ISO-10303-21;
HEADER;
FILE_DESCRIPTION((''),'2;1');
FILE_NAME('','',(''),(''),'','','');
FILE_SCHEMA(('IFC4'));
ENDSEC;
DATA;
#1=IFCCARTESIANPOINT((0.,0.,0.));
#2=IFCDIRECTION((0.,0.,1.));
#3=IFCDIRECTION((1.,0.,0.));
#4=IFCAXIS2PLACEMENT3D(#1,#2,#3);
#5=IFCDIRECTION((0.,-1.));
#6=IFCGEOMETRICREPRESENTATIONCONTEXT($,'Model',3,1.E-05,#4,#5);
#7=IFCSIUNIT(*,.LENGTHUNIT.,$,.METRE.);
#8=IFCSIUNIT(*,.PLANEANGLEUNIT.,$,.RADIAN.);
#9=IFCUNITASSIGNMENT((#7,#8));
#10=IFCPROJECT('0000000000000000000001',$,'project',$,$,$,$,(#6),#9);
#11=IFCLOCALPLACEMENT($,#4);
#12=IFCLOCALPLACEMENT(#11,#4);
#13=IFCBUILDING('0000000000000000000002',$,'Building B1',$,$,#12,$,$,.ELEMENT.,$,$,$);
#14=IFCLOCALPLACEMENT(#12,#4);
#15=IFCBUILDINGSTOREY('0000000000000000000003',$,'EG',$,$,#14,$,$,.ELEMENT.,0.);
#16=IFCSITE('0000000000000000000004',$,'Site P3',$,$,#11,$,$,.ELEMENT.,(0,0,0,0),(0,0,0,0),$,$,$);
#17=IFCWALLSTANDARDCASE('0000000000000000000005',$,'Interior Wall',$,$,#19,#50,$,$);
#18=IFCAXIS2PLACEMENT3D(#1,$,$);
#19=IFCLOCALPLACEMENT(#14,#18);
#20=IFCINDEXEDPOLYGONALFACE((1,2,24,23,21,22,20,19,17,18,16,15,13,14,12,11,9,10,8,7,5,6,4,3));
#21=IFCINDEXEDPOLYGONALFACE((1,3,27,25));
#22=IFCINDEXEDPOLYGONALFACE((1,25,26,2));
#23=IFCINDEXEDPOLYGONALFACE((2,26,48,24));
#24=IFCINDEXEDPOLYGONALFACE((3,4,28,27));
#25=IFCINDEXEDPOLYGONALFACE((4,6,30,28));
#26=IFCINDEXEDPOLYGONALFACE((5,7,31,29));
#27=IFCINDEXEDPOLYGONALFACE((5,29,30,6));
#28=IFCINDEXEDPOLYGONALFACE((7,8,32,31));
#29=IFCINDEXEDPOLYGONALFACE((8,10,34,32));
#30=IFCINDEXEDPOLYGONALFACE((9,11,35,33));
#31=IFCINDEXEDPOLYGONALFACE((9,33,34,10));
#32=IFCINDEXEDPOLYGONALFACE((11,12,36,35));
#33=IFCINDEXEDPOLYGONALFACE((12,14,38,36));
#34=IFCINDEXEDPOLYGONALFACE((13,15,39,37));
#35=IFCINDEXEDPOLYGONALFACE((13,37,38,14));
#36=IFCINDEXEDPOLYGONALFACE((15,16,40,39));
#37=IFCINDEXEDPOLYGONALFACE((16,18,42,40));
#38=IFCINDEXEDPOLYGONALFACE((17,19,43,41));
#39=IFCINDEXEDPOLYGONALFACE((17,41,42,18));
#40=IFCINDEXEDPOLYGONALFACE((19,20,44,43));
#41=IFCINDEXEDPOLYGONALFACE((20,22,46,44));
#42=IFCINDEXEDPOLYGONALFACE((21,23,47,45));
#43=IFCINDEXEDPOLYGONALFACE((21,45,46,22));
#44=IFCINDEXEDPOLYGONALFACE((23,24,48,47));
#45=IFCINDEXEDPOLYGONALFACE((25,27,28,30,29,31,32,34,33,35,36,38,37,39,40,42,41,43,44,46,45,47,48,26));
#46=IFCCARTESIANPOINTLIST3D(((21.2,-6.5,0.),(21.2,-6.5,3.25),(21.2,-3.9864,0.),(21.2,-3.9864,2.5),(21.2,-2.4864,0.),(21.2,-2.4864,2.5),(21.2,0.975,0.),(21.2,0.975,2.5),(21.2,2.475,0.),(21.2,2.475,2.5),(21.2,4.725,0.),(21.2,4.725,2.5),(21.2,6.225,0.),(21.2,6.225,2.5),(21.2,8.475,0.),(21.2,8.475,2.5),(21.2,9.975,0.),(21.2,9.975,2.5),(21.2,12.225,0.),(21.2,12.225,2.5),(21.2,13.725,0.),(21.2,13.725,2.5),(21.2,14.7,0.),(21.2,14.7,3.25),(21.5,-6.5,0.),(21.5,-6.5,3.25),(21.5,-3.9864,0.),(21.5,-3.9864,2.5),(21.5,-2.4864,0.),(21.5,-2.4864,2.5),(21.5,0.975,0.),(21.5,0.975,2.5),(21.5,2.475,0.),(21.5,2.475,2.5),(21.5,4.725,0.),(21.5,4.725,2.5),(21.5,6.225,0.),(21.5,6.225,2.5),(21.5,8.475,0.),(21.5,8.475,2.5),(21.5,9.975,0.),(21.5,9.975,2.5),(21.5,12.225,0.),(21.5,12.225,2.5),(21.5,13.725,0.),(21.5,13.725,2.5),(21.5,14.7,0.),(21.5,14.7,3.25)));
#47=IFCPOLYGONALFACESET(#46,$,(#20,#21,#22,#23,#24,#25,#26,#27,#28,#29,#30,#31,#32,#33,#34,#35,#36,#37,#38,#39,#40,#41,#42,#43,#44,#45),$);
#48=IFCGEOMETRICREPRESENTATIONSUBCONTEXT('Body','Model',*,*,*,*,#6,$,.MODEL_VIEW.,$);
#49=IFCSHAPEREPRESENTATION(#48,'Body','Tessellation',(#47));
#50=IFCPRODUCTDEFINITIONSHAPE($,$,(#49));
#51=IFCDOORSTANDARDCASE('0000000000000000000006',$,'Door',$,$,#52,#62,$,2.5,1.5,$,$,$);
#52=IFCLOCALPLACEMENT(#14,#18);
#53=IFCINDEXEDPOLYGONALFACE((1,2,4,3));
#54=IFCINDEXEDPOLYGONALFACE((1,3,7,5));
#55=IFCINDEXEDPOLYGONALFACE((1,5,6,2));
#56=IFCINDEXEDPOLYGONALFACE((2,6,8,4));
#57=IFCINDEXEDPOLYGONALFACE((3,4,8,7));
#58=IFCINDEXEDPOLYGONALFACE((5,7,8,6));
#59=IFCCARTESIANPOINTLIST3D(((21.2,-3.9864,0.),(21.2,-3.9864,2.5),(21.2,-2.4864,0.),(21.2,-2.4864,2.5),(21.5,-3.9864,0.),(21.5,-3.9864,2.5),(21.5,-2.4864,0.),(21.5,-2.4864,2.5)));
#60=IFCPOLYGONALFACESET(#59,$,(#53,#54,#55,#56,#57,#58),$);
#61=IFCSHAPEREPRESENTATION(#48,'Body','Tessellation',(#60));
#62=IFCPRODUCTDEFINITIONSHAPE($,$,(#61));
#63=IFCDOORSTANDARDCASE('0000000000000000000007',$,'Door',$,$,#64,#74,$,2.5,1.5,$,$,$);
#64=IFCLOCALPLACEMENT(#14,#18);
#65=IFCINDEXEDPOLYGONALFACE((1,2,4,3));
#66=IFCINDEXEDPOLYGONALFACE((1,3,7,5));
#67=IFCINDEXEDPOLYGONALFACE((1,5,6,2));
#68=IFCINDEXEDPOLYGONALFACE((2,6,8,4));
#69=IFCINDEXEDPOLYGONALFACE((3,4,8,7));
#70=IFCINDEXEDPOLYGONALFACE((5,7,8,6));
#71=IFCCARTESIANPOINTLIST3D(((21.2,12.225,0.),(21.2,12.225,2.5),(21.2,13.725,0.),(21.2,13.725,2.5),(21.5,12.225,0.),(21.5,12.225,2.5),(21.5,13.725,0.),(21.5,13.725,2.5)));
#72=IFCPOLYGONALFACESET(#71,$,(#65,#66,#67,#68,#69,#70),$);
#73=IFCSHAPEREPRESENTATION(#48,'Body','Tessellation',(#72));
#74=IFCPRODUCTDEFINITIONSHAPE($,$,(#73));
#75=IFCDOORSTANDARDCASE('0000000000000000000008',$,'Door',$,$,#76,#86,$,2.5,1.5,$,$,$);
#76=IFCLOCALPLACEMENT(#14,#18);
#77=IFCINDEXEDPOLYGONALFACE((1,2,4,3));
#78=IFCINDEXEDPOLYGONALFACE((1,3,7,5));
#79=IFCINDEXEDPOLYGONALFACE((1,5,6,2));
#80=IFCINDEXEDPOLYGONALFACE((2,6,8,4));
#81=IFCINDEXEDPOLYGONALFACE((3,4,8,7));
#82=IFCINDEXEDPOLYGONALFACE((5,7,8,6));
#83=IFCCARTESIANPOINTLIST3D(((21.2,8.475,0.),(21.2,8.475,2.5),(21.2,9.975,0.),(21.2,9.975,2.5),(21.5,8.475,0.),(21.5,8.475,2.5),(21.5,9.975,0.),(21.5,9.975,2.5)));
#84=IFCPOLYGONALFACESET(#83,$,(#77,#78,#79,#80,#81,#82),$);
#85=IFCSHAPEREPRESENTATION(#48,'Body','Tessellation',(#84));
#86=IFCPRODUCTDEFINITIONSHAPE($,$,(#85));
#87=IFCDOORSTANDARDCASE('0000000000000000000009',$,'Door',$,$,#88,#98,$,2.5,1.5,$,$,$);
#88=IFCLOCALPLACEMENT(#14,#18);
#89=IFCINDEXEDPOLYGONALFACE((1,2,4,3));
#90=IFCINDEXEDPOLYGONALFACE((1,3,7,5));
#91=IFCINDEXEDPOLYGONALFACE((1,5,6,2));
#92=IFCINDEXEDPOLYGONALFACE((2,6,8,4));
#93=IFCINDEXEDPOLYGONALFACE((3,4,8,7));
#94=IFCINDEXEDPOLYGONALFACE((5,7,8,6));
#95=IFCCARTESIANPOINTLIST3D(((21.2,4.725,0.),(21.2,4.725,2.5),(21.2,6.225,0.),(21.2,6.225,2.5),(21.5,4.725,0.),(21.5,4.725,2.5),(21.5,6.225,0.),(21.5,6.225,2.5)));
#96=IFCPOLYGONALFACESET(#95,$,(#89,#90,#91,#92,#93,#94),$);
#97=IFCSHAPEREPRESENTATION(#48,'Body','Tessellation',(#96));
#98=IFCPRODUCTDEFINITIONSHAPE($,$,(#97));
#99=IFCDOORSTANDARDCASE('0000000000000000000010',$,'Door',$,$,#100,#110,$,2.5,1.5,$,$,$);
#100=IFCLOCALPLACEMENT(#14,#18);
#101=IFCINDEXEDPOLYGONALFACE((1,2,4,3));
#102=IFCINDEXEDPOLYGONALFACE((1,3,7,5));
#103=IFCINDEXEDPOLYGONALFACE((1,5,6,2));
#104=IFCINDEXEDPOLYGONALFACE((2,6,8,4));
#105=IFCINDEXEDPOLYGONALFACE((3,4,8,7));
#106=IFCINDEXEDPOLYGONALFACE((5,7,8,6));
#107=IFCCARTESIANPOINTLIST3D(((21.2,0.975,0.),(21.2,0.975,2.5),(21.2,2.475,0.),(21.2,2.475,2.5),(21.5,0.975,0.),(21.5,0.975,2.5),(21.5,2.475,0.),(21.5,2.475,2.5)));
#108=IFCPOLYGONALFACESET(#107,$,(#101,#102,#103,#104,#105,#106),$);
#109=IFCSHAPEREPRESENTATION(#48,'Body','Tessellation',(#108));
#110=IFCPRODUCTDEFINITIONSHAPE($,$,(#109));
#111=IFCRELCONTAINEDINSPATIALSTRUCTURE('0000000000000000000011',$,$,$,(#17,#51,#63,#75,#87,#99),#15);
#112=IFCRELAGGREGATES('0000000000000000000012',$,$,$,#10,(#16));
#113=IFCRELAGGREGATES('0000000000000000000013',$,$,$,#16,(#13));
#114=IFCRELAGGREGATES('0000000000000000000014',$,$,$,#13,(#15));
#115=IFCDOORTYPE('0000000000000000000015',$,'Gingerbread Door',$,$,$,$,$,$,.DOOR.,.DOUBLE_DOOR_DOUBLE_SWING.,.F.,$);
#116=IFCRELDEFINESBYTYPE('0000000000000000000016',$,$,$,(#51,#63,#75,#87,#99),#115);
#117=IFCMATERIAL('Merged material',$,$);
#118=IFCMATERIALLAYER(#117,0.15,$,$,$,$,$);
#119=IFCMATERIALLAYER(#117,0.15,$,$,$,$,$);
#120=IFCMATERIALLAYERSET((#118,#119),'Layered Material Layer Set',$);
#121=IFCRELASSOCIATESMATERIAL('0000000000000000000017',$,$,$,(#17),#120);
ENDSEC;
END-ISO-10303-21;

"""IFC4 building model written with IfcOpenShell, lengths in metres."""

from ifc_helpers import new_model, si_unit, direction, frame, origin_with_axes, place, context, subcontext, project, spatial, polyline, outline, extrude, source, transform, mapped, material, layer, layer_set, layer_usage, type_object, element, fill, save


model = new_model("IFC4")

# Units and contexts
model_context = context("Model", 3, precision=1e-05, world=origin_with_axes(), true_north=direction((0.0, -1.0)))
body_context = subcontext(model_context, "Body", "Model", "MODEL_VIEW")
ifc_project = project(units=[si_unit("LENGTHUNIT", "METRE"), si_unit("PLANEANGLEUNIT", "RADIAN")], contexts=[model_context])

# Site, building, storey
site_placement = place(None, origin_with_axes())
site = spatial("IfcSite", under=ifc_project, at=site_placement, Name="Site P3", CompositionType="ELEMENT", RefLatitude=(0, 0, 0, 0), RefLongitude=(0, 0, 0, 0))
building_placement = place(site_placement, origin_with_axes())
building = spatial("IfcBuilding", under=site, at=building_placement, Name="Building B1", CompositionType="ELEMENT")
storey_placement = place(building_placement, origin_with_axes())
storey = spatial("IfcBuildingStorey", under=building, at=storey_placement, Name="EG", CompositionType="ELEMENT", Elevation=0.0)

# Shared definitions
ifc_material = material(Name="Merged material")

# Wall, openings, doors
ifc_layer_1 = layer(ifc_material, 0.15)
ifc_layer_2 = layer(ifc_material, 0.15)
ifc_layer_set_1 = layer_set([ifc_layer_1, ifc_layer_2], Name="Layered Material Layer Set")
ifc_layer_usage_1 = layer_usage(ifc_layer_set_1, "AXIS2", "POSITIVE", -0.15)
wall_1_placement = place(storey_placement, frame((21.35, 14.7, 0.0), z_axis=(0.0, 0.0, 1.0), x_axis=(0.0, -1.0, 0.0)))
wall_1 = element("IfcWallStandardCase", 1, at=wall_1_placement, inside=storey, material=ifc_layer_usage_1, Name="Interior Wall", context=body_context, shape_type="SweptSolid", body=[
    extrude(outline(polyline([(0.0, 0.15), (21.2, 0.15), (21.2, -0.15), (0.0, -0.15), (0.0, 0.15)])), origin_with_axes(), (0.0, 0.0, 1.0), 3.25),
])
opening_1_placement = place(wall_1_placement, frame((17.1864, 0.0, 0.0), z_axis=(0.0, 0.0, 1.0), x_axis=(1.0, 0.0, 0.0)))
opening_1 = element("IfcOpeningStandardCase", 2, at=opening_1_placement, cuts=wall_1, context=body_context, shape_type="SweptSolid", body=[
    extrude(outline(polyline([(0.0, 0.0), (0.0, 1.5), (2.5, 1.5), (2.5, 0.0), (0.0, 0.0)])), frame((0.0, -0.15, 0.0), z_axis=(0.0, 1.0, 0.0), x_axis=(0.0, 0.0, 1.0)), (0.0, 0.0, 1.0), 0.3),
])
opening_2_placement = place(wall_1_placement, frame((0.975, 0.0, 0.0), z_axis=(0.0, 0.0, 1.0), x_axis=(1.0, 0.0, 0.0)))
opening_2 = element("IfcOpeningStandardCase", 3, at=opening_2_placement, cuts=wall_1, context=body_context, shape_type="SweptSolid", body=[
    extrude(outline(polyline([(0.0, 0.0), (0.0, 1.5), (2.5, 1.5), (2.5, 0.0), (0.0, 0.0)])), frame((0.0, -0.15, 0.0), z_axis=(0.0, 1.0, 0.0), x_axis=(0.0, 0.0, 1.0)), (0.0, 0.0, 1.0), 0.3),
])
opening_3_placement = place(wall_1_placement, frame((4.725, 0.0, 0.0), z_axis=(0.0, 0.0, 1.0), x_axis=(1.0, 0.0, 0.0)))
opening_3 = element("IfcOpeningStandardCase", 4, at=opening_3_placement, cuts=wall_1, context=body_context, shape_type="SweptSolid", body=[
    extrude(outline(polyline([(0.0, 0.0), (0.0, 1.5), (2.5, 1.5), (2.5, 0.0), (0.0, 0.0)])), frame((0.0, -0.15, 0.0), z_axis=(0.0, 1.0, 0.0), x_axis=(0.0, 0.0, 1.0)), (0.0, 0.0, 1.0), 0.3),
])
opening_4_placement = place(wall_1_placement, frame((8.475, 0.0, 0.0), z_axis=(0.0, 0.0, 1.0), x_axis=(1.0, 0.0, 0.0)))
opening_4 = element("IfcOpeningStandardCase", 5, at=opening_4_placement, cuts=wall_1, context=body_context, shape_type="SweptSolid", body=[
    extrude(outline(polyline([(0.0, 0.0), (0.0, 1.5), (2.5, 1.5), (2.5, 0.0), (0.0, 0.0)])), frame((0.0, -0.15, 0.0), z_axis=(0.0, 1.0, 0.0), x_axis=(0.0, 0.0, 1.0)), (0.0, 0.0, 1.0), 0.3),
])
opening_5_placement = place(wall_1_placement, frame((12.225, 0.0, 0.0), z_axis=(0.0, 0.0, 1.0), x_axis=(1.0, 0.0, 0.0)))
opening_5 = element("IfcOpeningStandardCase", 6, at=opening_5_placement, cuts=wall_1, context=body_context, shape_type="SweptSolid", body=[
    extrude(outline(polyline([(0.0, 0.0), (0.0, 1.5), (2.5, 1.5), (2.5, 0.0), (0.0, 0.0)])), frame((0.0, -0.15, 0.0), z_axis=(0.0, 1.0, 0.0), x_axis=(0.0, 0.0, 1.0)), (0.0, 0.0, 1.0), 0.3),
])
door_type = type_object("IfcDoorType", Name="Gingerbread Door", OperationType="DOUBLE_DOOR_DOUBLE_SWING", ParameterTakesPrecedence=False, PredefinedType="DOOR")
shared_shape_1 = source(origin_with_axes(), body_context, "Body", "SweptSolid", [
    extrude(outline(polyline([(0.0, 0.0), (0.0, 1.5), (2.5, 1.5), (2.5, 0.0), (0.0, 0.0)])), frame((0.0, -0.15, 0.0), z_axis=(0.0, 1.0, 0.0), x_axis=(0.0, 0.0, 1.0)), (0.0, 0.0, 1.0), 0.3),
])
door_1_placement = place(opening_1_placement, origin_with_axes())
door_1 = element("IfcDoorStandardCase", 7, at=door_1_placement, inside=storey, type_object=door_type, Name="Door", OverallHeight=2.5, OverallWidth=1.5, context=body_context, shape_type="MappedRepresentation", body=[
    mapped(shared_shape_1, transform((0.0, 0.0, 0.0))),
])
fill(opening_1, door_1)
door_2_placement = place(opening_2_placement, origin_with_axes())
door_2 = element("IfcDoorStandardCase", 8, at=door_2_placement, inside=storey, type_object=door_type, Name="Door", OverallHeight=2.5, OverallWidth=1.5, context=body_context, shape_type="MappedRepresentation", body=[
    mapped(shared_shape_1, transform((0.0, 0.0, 0.0))),
])
fill(opening_2, door_2)
door_3_placement = place(opening_3_placement, origin_with_axes())
door_3 = element("IfcDoorStandardCase", 9, at=door_3_placement, inside=storey, type_object=door_type, Name="Door", OverallHeight=2.5, OverallWidth=1.5, context=body_context, shape_type="MappedRepresentation", body=[
    mapped(shared_shape_1, transform((0.0, 0.0, 0.0))),
])
fill(opening_3, door_3)
door_4_placement = place(opening_4_placement, origin_with_axes())
door_4 = element("IfcDoorStandardCase", 10, at=door_4_placement, inside=storey, type_object=door_type, Name="Door", OverallHeight=2.5, OverallWidth=1.5, context=body_context, shape_type="MappedRepresentation", body=[
    mapped(shared_shape_1, transform((0.0, 0.0, 0.0))),
])
fill(opening_4, door_4)
door_5_placement = place(opening_5_placement, origin_with_axes())
door_5 = element("IfcDoorStandardCase", 11, at=door_5_placement, inside=storey, type_object=door_type, Name="Door", OverallHeight=2.5, OverallWidth=1.5, context=body_context, shape_type="MappedRepresentation", body=[
    mapped(shared_shape_1, transform((0.0, 0.0, 0.0))),
])
fill(opening_5, door_5)

save(model, "model.ifc")
